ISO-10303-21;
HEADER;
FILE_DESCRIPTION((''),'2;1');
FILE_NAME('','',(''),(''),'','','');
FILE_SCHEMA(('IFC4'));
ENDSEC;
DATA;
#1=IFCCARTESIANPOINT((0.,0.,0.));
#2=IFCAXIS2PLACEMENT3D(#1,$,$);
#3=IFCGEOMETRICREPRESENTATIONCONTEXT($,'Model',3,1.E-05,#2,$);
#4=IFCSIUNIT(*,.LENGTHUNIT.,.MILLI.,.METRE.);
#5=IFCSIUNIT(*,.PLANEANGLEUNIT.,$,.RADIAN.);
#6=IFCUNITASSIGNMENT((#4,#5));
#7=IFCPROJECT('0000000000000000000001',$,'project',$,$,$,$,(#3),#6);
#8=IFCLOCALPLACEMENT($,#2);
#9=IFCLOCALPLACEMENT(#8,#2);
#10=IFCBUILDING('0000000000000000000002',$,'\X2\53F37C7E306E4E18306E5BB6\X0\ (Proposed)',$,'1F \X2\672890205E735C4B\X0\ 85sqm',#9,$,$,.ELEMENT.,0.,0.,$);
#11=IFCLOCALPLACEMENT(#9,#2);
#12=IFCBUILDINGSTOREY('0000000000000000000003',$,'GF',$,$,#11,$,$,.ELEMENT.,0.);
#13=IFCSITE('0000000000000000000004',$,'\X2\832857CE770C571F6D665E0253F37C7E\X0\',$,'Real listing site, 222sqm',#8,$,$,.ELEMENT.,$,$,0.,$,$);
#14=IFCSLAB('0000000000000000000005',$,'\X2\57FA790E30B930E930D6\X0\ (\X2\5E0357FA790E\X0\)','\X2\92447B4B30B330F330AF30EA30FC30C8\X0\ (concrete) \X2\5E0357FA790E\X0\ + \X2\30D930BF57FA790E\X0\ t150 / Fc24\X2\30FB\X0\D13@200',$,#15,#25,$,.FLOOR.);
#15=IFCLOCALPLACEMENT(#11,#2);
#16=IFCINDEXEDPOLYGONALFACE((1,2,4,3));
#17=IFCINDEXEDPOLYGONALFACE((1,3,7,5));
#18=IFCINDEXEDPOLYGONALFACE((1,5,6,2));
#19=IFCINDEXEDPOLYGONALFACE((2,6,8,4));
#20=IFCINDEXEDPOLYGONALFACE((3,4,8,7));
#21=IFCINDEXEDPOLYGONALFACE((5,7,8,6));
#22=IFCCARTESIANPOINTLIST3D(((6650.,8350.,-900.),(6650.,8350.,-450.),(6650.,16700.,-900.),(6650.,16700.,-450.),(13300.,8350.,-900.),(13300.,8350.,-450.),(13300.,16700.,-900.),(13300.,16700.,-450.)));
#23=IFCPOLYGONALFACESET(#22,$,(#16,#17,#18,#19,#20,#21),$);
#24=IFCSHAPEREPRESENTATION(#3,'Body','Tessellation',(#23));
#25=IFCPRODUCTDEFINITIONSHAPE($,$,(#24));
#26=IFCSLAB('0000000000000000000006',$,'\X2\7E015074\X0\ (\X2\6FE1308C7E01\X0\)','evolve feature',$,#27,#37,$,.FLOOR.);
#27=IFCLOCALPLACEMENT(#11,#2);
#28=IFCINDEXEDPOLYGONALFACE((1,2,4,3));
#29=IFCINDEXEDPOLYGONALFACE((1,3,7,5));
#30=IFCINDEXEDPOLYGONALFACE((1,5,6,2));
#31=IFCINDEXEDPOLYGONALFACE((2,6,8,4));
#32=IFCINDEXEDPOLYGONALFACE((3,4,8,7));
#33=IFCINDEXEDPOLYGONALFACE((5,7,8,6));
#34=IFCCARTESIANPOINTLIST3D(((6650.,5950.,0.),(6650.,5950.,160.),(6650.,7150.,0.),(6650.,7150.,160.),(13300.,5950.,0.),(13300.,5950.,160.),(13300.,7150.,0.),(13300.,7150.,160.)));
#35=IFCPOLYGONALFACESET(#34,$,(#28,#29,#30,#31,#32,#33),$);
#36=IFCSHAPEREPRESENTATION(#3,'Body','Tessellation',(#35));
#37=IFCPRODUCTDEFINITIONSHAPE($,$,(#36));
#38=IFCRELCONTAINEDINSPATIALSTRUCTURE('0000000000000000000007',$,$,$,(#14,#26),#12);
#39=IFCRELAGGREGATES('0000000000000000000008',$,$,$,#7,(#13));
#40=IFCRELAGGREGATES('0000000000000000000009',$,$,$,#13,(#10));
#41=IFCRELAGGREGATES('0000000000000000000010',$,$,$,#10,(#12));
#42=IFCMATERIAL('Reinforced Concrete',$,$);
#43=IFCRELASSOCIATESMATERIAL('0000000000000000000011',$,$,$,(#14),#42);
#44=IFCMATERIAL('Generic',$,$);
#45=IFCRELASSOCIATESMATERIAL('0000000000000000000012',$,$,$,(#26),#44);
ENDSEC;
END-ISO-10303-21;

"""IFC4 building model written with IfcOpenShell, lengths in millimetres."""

from ifc_helpers import new_model, si_unit, frame, frame_2d, origin, place, context, project, spatial, rectangle, extrude, material, element, save


model = new_model("IFC4")

# Units and contexts
model_context = context("Model", 3, precision=1e-05, world=origin())
ifc_project = project(units=[si_unit("LENGTHUNIT", "METRE", prefix="MILLI"), si_unit("PLANEANGLEUNIT", "RADIAN")], contexts=[model_context])

# Site, building, storey
site_placement = place(None, origin())
site = spatial("IfcSite", under=ifc_project, at=site_placement, Name="茨城県土浦市右籾", ObjectType="Real listing site, 222sqm", CompositionType="ELEMENT", RefElevation=0.0)
building_placement = place(site_placement, origin())
building = spatial("IfcBuilding", under=site, at=building_placement, Name="右籾の丘の家 (Proposed)", ObjectType="1F 木造平屋 85sqm", CompositionType="ELEMENT", ElevationOfRefHeight=0.0, ElevationOfTerrain=0.0)
storey_placement = place(building_placement, origin())
storey = spatial("IfcBuildingStorey", under=building, at=storey_placement, Name="GF", CompositionType="ELEMENT", Elevation=0.0)

# Slabs
ifc_material_1 = material(Name="Reinforced Concrete")
slab_1_placement = place(storey_placement, frame((3325.0, 4175.0, -450.0)))
element("IfcSlab", 1, at=slab_1_placement, inside=storey, material=ifc_material_1, Name="基礎スラブ (布基礎)", Description="鉄筋コンクリート (concrete) 布基礎 + ベタ基礎 t150 / Fc24・D13@200", PredefinedType="FLOOR", context=model_context, shape_type="SweptSolid", body=[
    extrude(rectangle(XDim=6650.0, YDim=8350.0, at=frame_2d((3325.0, 4175.0))), frame((3325.0, 4175.0, -450.0)), (0.0, 0.0, 1.0), 450.0),
])
ifc_material_2 = material(Name="Generic")
slab_2_placement = place(storey_placement, frame((3325.0, 2975.0, 0.0)))
element("IfcSlab", 2, at=slab_2_placement, inside=storey, material=ifc_material_2, Name="縁側 (濡れ縁)", Description="evolve feature", PredefinedType="FLOOR", context=model_context, shape_type="SweptSolid", body=[
    extrude(rectangle(XDim=6650.0, YDim=1200.0, at=frame_2d((3325.0, 600.0))), frame((3325.0, 2975.0, 0.0)), (0.0, 0.0, 1.0), 160.0),
])

save(model, "model.ifc")
